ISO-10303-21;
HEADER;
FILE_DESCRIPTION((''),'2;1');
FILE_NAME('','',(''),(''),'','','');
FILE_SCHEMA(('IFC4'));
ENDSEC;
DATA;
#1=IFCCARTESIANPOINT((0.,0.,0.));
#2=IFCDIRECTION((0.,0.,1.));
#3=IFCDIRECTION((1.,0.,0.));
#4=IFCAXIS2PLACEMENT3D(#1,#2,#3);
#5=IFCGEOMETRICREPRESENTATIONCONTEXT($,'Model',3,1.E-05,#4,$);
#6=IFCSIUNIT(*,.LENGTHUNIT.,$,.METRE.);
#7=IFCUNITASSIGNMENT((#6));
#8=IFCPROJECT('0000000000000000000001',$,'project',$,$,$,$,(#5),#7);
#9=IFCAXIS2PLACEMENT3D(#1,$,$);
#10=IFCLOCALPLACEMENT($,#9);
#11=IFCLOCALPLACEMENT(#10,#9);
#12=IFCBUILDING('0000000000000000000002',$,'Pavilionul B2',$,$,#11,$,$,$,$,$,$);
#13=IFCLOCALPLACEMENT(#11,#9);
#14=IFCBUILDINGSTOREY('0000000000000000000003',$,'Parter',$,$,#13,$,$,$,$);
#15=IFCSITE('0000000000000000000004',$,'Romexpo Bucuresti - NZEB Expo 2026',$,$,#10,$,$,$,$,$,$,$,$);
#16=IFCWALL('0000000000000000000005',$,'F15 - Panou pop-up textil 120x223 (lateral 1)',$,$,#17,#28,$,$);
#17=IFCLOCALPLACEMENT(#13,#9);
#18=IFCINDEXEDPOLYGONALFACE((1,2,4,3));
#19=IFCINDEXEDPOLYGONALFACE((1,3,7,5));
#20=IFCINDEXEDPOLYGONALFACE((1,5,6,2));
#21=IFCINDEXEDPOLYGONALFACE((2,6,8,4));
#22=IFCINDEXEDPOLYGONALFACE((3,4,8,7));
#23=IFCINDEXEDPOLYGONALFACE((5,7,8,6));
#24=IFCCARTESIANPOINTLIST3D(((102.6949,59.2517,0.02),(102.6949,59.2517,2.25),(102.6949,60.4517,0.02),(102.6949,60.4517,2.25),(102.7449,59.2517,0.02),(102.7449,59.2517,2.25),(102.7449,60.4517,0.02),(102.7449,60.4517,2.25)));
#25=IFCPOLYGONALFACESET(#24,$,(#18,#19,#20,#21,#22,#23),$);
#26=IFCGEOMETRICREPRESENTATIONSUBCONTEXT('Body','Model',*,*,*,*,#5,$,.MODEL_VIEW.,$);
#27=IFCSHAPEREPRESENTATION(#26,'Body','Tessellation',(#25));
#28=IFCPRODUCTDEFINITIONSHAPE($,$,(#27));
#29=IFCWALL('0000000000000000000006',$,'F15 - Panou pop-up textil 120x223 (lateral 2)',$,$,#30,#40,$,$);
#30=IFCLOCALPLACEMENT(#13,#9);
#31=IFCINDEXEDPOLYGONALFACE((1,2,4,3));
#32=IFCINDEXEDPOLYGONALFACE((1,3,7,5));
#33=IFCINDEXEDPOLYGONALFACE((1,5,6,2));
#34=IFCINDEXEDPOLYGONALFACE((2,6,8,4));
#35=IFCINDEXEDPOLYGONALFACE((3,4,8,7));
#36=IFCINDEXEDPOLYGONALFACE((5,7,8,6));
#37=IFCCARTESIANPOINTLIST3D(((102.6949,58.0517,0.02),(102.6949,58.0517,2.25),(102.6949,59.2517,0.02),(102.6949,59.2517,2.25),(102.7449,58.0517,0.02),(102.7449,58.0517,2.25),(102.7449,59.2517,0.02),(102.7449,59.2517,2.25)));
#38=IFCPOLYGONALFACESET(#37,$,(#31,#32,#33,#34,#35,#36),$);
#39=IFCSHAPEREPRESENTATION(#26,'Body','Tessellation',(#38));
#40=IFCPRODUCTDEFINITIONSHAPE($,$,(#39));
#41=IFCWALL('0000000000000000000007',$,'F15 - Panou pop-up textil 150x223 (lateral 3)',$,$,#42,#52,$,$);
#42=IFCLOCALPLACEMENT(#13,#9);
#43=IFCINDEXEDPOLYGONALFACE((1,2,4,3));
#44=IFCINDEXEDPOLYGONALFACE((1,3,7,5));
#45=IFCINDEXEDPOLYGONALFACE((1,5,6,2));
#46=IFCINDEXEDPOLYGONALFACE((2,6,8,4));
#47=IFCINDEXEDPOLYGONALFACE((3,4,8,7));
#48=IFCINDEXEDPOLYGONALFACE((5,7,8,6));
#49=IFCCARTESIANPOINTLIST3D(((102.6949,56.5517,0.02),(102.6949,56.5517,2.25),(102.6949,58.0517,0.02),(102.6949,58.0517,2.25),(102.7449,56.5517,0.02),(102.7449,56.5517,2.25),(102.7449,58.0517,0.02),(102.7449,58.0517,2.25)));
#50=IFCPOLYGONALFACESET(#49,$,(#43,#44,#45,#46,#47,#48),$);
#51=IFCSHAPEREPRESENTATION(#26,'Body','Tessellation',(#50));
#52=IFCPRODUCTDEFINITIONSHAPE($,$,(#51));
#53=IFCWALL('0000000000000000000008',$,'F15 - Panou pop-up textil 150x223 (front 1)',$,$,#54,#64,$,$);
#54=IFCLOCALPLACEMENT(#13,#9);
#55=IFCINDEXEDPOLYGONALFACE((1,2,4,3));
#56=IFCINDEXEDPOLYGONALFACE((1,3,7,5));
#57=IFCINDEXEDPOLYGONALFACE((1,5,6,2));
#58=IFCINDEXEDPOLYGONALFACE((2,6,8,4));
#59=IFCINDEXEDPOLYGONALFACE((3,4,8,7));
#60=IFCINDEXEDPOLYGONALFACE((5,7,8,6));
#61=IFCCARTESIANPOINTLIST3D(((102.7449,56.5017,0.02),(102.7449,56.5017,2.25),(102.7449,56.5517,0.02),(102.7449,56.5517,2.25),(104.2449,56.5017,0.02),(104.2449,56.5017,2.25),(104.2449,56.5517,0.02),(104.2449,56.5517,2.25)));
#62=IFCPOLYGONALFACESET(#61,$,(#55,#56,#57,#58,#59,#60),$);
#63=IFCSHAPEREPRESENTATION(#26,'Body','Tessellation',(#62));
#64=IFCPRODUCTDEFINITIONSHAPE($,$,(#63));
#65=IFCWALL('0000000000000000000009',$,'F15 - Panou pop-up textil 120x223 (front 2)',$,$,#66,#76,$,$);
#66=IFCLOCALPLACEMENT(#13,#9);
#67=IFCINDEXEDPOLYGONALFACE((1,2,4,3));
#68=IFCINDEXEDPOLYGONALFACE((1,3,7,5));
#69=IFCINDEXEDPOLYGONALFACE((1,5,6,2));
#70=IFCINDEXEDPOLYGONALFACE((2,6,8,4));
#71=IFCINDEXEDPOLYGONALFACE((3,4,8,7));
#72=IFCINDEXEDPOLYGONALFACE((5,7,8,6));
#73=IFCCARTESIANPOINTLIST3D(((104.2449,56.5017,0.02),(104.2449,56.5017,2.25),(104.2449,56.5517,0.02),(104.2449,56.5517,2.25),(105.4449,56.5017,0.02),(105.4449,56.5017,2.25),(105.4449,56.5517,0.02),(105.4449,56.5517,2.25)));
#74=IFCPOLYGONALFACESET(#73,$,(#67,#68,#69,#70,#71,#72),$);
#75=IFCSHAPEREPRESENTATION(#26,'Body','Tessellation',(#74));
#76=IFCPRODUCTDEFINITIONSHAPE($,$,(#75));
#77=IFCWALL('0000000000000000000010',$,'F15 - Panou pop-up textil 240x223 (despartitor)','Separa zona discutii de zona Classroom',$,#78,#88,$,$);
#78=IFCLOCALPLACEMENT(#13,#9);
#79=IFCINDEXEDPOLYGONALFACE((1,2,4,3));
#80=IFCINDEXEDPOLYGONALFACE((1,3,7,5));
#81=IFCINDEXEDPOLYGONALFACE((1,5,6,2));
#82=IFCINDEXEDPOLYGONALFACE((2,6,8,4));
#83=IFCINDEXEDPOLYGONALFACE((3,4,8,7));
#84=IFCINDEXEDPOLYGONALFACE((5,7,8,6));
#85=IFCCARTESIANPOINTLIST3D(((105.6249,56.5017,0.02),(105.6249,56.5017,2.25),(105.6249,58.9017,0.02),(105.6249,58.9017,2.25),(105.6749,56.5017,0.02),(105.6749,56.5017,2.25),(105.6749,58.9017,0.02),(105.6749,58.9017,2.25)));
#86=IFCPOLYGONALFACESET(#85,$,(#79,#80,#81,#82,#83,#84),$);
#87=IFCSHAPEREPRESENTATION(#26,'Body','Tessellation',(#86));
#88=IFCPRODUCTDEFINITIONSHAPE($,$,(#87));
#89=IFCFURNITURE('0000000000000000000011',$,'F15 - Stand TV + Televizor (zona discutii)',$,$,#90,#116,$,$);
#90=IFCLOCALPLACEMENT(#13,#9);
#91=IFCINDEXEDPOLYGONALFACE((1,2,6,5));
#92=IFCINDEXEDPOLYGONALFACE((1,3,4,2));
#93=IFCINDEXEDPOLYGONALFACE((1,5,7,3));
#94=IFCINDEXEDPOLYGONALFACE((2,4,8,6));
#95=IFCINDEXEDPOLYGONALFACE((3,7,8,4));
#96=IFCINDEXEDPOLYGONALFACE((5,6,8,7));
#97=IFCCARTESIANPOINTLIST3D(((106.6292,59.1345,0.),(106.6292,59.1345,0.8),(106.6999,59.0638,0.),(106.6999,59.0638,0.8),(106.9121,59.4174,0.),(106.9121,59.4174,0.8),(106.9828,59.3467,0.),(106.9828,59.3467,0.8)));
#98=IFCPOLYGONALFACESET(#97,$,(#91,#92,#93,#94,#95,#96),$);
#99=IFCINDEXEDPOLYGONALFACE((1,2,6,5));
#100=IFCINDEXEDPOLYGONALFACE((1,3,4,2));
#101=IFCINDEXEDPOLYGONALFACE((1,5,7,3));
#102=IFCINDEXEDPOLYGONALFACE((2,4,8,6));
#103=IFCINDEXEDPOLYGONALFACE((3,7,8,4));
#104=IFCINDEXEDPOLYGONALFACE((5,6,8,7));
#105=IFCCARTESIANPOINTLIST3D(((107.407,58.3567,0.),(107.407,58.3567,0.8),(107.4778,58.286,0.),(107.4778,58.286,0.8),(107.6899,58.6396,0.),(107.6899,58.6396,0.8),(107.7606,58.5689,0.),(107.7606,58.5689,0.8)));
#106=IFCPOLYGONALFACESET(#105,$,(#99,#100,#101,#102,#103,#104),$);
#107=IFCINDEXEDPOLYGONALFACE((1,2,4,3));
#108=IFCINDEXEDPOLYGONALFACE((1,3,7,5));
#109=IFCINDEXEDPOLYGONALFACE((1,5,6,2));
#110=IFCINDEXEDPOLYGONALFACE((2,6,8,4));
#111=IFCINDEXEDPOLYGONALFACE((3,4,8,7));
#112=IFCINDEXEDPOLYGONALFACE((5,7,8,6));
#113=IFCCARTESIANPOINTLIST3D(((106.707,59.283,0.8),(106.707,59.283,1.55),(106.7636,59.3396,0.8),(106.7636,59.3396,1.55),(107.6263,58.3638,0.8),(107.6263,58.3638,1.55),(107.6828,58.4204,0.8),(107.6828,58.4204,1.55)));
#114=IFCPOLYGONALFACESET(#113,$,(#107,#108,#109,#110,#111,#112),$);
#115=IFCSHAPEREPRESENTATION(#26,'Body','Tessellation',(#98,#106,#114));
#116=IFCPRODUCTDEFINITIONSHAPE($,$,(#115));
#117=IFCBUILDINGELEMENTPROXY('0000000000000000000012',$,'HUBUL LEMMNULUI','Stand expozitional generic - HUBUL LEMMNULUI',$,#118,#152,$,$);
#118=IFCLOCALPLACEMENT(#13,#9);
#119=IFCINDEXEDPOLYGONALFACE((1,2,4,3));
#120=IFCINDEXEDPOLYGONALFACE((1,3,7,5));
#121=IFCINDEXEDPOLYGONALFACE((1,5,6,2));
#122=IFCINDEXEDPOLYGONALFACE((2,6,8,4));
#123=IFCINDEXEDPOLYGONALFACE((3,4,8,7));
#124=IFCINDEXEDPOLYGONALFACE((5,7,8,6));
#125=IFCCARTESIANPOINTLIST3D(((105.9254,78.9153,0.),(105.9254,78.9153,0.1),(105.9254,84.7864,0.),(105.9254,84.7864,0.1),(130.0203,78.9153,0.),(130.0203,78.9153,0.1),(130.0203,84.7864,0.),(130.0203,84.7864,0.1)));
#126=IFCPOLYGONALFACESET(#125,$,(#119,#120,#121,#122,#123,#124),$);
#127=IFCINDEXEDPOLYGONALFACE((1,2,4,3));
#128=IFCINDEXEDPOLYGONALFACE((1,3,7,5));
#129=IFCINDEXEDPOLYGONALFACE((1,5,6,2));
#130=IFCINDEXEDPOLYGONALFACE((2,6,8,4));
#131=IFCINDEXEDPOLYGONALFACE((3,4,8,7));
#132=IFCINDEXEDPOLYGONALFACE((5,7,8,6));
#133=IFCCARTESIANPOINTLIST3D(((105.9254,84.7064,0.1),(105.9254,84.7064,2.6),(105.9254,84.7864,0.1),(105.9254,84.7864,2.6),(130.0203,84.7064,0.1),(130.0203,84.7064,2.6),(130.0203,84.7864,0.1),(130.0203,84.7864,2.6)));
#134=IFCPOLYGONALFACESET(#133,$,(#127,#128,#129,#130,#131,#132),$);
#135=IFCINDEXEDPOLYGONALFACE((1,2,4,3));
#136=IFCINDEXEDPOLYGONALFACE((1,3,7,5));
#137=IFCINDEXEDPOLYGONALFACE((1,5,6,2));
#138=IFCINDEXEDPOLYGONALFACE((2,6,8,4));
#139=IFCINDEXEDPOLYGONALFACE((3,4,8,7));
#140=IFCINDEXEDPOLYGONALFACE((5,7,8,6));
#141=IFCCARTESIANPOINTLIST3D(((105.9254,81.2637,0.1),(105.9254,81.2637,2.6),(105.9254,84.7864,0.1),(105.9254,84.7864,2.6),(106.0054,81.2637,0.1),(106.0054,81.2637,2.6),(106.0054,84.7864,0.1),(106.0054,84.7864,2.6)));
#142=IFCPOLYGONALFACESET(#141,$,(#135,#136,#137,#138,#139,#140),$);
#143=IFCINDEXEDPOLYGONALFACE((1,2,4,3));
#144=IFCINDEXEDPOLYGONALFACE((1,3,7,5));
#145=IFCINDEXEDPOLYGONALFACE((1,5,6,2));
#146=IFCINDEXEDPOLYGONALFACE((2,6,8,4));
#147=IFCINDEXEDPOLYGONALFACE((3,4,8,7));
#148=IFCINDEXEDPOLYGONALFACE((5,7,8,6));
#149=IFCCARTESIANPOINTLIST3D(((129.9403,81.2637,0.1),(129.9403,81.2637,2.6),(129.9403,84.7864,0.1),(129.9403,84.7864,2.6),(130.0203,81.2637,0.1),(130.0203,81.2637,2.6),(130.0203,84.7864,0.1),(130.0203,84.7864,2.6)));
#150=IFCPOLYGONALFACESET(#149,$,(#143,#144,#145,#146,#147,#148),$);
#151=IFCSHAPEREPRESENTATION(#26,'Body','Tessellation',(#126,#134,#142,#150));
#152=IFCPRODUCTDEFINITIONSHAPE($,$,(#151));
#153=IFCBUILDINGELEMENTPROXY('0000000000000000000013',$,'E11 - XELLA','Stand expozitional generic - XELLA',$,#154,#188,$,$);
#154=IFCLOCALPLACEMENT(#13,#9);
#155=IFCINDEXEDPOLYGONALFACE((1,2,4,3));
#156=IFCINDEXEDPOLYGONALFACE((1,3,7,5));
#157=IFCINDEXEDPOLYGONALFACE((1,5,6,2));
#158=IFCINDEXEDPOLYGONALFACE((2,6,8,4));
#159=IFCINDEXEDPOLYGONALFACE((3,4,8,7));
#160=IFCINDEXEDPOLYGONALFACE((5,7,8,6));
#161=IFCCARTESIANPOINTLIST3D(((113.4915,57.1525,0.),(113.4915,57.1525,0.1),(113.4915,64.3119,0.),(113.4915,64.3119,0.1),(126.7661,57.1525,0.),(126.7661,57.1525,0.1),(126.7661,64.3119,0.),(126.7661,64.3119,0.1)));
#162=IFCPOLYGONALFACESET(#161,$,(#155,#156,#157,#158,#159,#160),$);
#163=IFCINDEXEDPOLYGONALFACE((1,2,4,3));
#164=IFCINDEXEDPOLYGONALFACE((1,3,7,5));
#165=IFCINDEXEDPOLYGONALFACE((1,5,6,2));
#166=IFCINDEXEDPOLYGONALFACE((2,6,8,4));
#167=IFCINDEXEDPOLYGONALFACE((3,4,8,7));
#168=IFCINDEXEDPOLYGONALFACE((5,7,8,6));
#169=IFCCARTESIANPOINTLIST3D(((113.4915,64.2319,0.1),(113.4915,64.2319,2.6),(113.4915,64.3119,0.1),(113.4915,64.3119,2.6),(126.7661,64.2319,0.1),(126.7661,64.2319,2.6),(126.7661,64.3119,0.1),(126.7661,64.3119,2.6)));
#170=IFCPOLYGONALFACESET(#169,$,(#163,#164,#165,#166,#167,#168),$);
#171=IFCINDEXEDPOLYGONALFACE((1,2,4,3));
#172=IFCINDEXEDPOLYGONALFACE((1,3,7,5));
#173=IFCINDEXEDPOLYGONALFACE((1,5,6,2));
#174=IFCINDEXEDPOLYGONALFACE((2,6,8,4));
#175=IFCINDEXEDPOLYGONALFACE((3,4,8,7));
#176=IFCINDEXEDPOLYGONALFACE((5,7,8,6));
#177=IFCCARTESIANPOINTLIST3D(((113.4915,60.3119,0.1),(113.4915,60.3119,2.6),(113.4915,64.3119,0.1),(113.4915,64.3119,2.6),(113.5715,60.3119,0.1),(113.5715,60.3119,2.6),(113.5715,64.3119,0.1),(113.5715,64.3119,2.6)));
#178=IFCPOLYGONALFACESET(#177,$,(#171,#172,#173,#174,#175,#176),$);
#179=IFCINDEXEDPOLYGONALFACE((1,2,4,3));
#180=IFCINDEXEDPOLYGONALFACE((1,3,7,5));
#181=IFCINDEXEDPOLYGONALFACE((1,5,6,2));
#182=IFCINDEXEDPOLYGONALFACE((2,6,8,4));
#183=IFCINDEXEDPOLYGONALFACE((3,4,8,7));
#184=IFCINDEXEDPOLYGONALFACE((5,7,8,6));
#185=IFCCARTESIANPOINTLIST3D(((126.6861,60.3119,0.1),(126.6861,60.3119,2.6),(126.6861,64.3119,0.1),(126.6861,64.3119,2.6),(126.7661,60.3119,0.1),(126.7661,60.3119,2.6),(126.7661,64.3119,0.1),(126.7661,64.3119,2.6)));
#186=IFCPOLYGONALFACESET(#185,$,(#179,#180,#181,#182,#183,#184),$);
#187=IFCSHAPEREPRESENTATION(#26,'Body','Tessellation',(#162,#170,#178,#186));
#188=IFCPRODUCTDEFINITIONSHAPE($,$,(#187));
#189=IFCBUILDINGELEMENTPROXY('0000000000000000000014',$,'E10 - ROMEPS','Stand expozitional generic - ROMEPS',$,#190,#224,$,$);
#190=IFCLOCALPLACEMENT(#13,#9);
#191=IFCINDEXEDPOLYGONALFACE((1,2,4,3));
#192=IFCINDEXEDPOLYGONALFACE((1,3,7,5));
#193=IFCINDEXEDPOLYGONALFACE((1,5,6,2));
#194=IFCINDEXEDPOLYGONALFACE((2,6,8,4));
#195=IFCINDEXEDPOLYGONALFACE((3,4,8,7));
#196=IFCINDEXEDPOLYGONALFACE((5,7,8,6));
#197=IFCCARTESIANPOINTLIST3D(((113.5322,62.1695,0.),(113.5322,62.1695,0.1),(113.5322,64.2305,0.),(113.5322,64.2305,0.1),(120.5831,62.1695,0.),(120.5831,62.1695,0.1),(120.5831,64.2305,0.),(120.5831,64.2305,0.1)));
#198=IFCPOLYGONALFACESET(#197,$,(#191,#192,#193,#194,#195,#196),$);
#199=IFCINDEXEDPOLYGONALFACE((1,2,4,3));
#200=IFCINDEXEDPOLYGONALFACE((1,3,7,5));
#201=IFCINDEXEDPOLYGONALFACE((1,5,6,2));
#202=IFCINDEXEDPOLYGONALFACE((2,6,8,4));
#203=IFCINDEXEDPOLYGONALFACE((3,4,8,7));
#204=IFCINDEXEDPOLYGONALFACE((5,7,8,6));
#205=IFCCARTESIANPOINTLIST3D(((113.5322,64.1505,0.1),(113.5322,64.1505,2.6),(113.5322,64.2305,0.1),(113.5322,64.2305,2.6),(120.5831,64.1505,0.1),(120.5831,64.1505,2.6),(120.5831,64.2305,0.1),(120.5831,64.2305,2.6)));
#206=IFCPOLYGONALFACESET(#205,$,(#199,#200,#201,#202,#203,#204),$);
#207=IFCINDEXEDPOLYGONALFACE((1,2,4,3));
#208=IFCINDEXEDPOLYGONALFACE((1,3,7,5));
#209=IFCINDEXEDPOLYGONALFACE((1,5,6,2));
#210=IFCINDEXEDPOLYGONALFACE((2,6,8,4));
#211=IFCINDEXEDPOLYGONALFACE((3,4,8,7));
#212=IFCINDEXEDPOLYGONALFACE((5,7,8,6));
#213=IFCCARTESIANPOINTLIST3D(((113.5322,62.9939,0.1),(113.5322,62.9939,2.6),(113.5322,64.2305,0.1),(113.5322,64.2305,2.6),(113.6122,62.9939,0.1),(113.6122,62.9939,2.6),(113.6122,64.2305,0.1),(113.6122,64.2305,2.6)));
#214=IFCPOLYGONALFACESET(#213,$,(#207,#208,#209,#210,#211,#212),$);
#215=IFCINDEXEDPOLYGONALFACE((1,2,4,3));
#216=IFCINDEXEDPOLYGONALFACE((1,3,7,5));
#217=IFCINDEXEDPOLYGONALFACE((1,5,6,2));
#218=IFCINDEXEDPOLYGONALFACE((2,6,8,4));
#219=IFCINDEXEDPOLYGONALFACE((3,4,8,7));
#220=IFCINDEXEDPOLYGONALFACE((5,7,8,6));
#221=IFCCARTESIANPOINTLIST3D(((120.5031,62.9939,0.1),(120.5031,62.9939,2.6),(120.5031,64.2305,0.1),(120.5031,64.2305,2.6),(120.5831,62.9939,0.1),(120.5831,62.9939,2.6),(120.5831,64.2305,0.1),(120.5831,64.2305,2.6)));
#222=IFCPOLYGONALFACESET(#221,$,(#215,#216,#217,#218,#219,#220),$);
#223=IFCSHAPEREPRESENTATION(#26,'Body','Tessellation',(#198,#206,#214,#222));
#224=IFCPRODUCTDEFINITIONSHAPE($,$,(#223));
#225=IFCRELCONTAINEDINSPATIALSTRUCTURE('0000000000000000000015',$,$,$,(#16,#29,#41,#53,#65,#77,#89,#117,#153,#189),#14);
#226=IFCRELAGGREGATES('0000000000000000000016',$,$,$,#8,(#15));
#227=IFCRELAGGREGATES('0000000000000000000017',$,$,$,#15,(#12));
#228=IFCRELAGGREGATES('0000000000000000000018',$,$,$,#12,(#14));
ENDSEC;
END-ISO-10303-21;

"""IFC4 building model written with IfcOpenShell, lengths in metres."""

from ifc_helpers import new_model, si_unit, frame, frame_2d, origin, origin_with_axes, origin_2d, place, context, subcontext, project, spatial, rectangle, extrude, element, save


model = new_model("IFC4")

# Units and contexts
model_context = context("Model", 3, precision=1e-05, world=origin_with_axes())
body_context = subcontext(model_context, "Body", "Model", "MODEL_VIEW")
ifc_project = project(units=[si_unit("LENGTHUNIT", "METRE")], contexts=[model_context])

# Site, building, storey
site_placement = place(None, origin())
site = spatial("IfcSite", under=ifc_project, at=site_placement, Name="Romexpo Bucuresti - NZEB Expo 2026")
building_placement = place(site_placement, origin())
building = spatial("IfcBuilding", under=site, at=building_placement, Name="Pavilionul B2")
storey_placement = place(building_placement, origin())
storey = spatial("IfcBuildingStorey", under=building, at=storey_placement, Name="Parter")

# Walls
wall_1_placement = place(storey_placement, frame((102.6949, 56.5017, 0.0), z_axis=(0.0, 0.0, 1.0), x_axis=(1.0, 0.0, 0.0)))
element("IfcWall", 1, at=wall_1_placement, inside=storey, Name="F15 - Panou pop-up textil 120x223 (lateral 1)", context=body_context, shape_type="SweptSolid", body=[
    extrude(rectangle(XDim=0.05, YDim=1.2, at=frame_2d((0.025, 3.35))), frame((0.0, 0.0, 0.02)), (0.0, 0.0, 1.0), 2.23),
])
wall_2_placement = place(storey_placement, frame((102.6949, 56.5017, 0.0), z_axis=(0.0, 0.0, 1.0), x_axis=(1.0, 0.0, 0.0)))
element("IfcWall", 2, at=wall_2_placement, inside=storey, Name="F15 - Panou pop-up textil 120x223 (lateral 2)", context=body_context, shape_type="SweptSolid", body=[
    extrude(rectangle(XDim=0.05, YDim=1.2, at=frame_2d((0.025, 2.15))), frame((0.0, 0.0, 0.02)), (0.0, 0.0, 1.0), 2.23),
])
wall_3_placement = place(storey_placement, frame((102.6949, 56.5017, 0.0), z_axis=(0.0, 0.0, 1.0), x_axis=(1.0, 0.0, 0.0)))
element("IfcWall", 3, at=wall_3_placement, inside=storey, Name="F15 - Panou pop-up textil 150x223 (lateral 3)", context=body_context, shape_type="SweptSolid", body=[
    extrude(rectangle(XDim=0.05, YDim=1.5, at=frame_2d((0.025, 0.8))), frame((0.0, 0.0, 0.02)), (0.0, 0.0, 1.0), 2.23),
])
wall_4_placement = place(storey_placement, frame((102.6949, 56.5017, 0.0), z_axis=(0.0, 0.0, 1.0), x_axis=(1.0, 0.0, 0.0)))
element("IfcWall", 4, at=wall_4_placement, inside=storey, Name="F15 - Panou pop-up textil 150x223 (front 1)", context=body_context, shape_type="SweptSolid", body=[
    extrude(rectangle(XDim=1.5, YDim=0.05, at=frame_2d((0.8, 0.025))), frame((0.0, 0.0, 0.02)), (0.0, 0.0, 1.0), 2.23),
])
wall_5_placement = place(storey_placement, frame((102.6949, 56.5017, 0.0), z_axis=(0.0, 0.0, 1.0), x_axis=(1.0, 0.0, 0.0)))
element("IfcWall", 5, at=wall_5_placement, inside=storey, Name="F15 - Panou pop-up textil 120x223 (front 2)", context=body_context, shape_type="SweptSolid", body=[
    extrude(rectangle(XDim=1.2, YDim=0.05, at=frame_2d((2.15, 0.025))), frame((0.0, 0.0, 0.02)), (0.0, 0.0, 1.0), 2.23),
])
wall_6_placement = place(storey_placement, frame((102.6949, 56.5017, 0.0), z_axis=(0.0, 0.0, 1.0), x_axis=(1.0, 0.0, 0.0)))
element("IfcWall", 6, at=wall_6_placement, inside=storey, Name="F15 - Panou pop-up textil 240x223 (despartitor)", Description="Separa zona discutii de zona Classroom", context=body_context, shape_type="SweptSolid", body=[
    extrude(rectangle(XDim=0.05, YDim=2.4, at=frame_2d((2.955, 1.2))), frame((0.0, 0.0, 0.02)), (0.0, 0.0, 1.0), 2.23),
])

# Furniture
furniture_1_placement = place(storey_placement, frame((107.1949, 58.8517, 0.0), z_axis=(0.0, 0.0, 1.0), x_axis=(0.707107, -0.707107, 0.0)))
element("IfcFurniture", 7, at=furniture_1_placement, inside=storey, Name="F15 - Stand TV + Televizor (zona discutii)", context=body_context, shape_type="SweptSolid", body=[
    extrude(rectangle(XDim=0.1, YDim=0.4, at=frame_2d((-0.55, 0.0))), origin(), (0.0, 0.0, 1.0), 0.8),
    extrude(rectangle(XDim=0.1, YDim=0.4, at=frame_2d((0.55, 0.0))), origin(), (0.0, 0.0, 1.0), 0.8),
    extrude(rectangle(XDim=1.3, YDim=0.08, at=origin_2d()), frame((0.0, 0.0, 0.8)), (0.0, 0.0, 1.0), 0.75),
])

# Building element proxies
proxy_1_placement = place(storey_placement, frame((105.9254, 78.9153, 0.0), z_axis=(0.0, 0.0, 1.0), x_axis=(1.0, 0.0, 0.0)))
element("IfcBuildingElementProxy", 8, at=proxy_1_placement, inside=storey, Name="HUBUL LEMMNULUI", Description="Stand expozitional generic - HUBUL LEMMNULUI", context=body_context, shape_type="SweptSolid", body=[
    extrude(rectangle(XDim=24.0949, YDim=5.8712, at=frame_2d((12.0475, 2.9356))), origin(), (0.0, 0.0, 1.0), 0.1),
    extrude(rectangle(XDim=24.0949, YDim=0.08, at=frame_2d((12.0475, 5.8312))), frame((0.0, 0.0, 0.1)), (0.0, 0.0, 1.0), 2.5),
    extrude(rectangle(XDim=0.08, YDim=3.5227, at=frame_2d((0.04, 4.1098))), frame((0.0, 0.0, 0.1)), (0.0, 0.0, 1.0), 2.5),
    extrude(rectangle(XDim=0.08, YDim=3.5227, at=frame_2d((24.0549, 4.1098))), frame((0.0, 0.0, 0.1)), (0.0, 0.0, 1.0), 2.5),
])
proxy_2_placement = place(storey_placement, frame((113.4915, 57.1525, 0.0), z_axis=(0.0, 0.0, 1.0), x_axis=(1.0, 0.0, 0.0)))
element("IfcBuildingElementProxy", 9, at=proxy_2_placement, inside=storey, Name="E11 - XELLA", Description="Stand expozitional generic - XELLA", context=body_context, shape_type="SweptSolid", body=[
    extrude(rectangle(XDim=13.2746, YDim=7.1593, at=frame_2d((6.6373, 3.5797))), origin(), (0.0, 0.0, 1.0), 0.1),
    extrude(rectangle(XDim=13.2746, YDim=0.08, at=frame_2d((6.6373, 7.1193))), frame((0.0, 0.0, 0.1)), (0.0, 0.0, 1.0), 2.5),
    extrude(rectangle(XDim=0.08, YDim=4.0, at=frame_2d((0.04, 5.1593))), frame((0.0, 0.0, 0.1)), (0.0, 0.0, 1.0), 2.5),
    extrude(rectangle(XDim=0.08, YDim=4.0, at=frame_2d((13.2346, 5.1593))), frame((0.0, 0.0, 0.1)), (0.0, 0.0, 1.0), 2.5),
])
proxy_3_placement = place(storey_placement, frame((113.5322, 62.1695, 0.0), z_axis=(0.0, 0.0, 1.0), x_axis=(1.0, 0.0, 0.0)))
element("IfcBuildingElementProxy", 10, at=proxy_3_placement, inside=storey, Name="E10 - ROMEPS", Description="Stand expozitional generic - ROMEPS", context=body_context, shape_type="SweptSolid", body=[
    extrude(rectangle(XDim=7.0508, YDim=2.061, at=frame_2d((3.5254, 1.0305))), origin(), (0.0, 0.0, 1.0), 0.1),
    extrude(rectangle(XDim=7.0508, YDim=0.08, at=frame_2d((3.5254, 2.021))), frame((0.0, 0.0, 0.1)), (0.0, 0.0, 1.0), 2.5),
    extrude(rectangle(XDim=0.08, YDim=1.2366, at=frame_2d((0.04, 1.4427))), frame((0.0, 0.0, 0.1)), (0.0, 0.0, 1.0), 2.5),
    extrude(rectangle(XDim=0.08, YDim=1.2366, at=frame_2d((7.0108, 1.4427))), frame((0.0, 0.0, 0.1)), (0.0, 0.0, 1.0), 2.5),
])

save(model, "model.ifc")
